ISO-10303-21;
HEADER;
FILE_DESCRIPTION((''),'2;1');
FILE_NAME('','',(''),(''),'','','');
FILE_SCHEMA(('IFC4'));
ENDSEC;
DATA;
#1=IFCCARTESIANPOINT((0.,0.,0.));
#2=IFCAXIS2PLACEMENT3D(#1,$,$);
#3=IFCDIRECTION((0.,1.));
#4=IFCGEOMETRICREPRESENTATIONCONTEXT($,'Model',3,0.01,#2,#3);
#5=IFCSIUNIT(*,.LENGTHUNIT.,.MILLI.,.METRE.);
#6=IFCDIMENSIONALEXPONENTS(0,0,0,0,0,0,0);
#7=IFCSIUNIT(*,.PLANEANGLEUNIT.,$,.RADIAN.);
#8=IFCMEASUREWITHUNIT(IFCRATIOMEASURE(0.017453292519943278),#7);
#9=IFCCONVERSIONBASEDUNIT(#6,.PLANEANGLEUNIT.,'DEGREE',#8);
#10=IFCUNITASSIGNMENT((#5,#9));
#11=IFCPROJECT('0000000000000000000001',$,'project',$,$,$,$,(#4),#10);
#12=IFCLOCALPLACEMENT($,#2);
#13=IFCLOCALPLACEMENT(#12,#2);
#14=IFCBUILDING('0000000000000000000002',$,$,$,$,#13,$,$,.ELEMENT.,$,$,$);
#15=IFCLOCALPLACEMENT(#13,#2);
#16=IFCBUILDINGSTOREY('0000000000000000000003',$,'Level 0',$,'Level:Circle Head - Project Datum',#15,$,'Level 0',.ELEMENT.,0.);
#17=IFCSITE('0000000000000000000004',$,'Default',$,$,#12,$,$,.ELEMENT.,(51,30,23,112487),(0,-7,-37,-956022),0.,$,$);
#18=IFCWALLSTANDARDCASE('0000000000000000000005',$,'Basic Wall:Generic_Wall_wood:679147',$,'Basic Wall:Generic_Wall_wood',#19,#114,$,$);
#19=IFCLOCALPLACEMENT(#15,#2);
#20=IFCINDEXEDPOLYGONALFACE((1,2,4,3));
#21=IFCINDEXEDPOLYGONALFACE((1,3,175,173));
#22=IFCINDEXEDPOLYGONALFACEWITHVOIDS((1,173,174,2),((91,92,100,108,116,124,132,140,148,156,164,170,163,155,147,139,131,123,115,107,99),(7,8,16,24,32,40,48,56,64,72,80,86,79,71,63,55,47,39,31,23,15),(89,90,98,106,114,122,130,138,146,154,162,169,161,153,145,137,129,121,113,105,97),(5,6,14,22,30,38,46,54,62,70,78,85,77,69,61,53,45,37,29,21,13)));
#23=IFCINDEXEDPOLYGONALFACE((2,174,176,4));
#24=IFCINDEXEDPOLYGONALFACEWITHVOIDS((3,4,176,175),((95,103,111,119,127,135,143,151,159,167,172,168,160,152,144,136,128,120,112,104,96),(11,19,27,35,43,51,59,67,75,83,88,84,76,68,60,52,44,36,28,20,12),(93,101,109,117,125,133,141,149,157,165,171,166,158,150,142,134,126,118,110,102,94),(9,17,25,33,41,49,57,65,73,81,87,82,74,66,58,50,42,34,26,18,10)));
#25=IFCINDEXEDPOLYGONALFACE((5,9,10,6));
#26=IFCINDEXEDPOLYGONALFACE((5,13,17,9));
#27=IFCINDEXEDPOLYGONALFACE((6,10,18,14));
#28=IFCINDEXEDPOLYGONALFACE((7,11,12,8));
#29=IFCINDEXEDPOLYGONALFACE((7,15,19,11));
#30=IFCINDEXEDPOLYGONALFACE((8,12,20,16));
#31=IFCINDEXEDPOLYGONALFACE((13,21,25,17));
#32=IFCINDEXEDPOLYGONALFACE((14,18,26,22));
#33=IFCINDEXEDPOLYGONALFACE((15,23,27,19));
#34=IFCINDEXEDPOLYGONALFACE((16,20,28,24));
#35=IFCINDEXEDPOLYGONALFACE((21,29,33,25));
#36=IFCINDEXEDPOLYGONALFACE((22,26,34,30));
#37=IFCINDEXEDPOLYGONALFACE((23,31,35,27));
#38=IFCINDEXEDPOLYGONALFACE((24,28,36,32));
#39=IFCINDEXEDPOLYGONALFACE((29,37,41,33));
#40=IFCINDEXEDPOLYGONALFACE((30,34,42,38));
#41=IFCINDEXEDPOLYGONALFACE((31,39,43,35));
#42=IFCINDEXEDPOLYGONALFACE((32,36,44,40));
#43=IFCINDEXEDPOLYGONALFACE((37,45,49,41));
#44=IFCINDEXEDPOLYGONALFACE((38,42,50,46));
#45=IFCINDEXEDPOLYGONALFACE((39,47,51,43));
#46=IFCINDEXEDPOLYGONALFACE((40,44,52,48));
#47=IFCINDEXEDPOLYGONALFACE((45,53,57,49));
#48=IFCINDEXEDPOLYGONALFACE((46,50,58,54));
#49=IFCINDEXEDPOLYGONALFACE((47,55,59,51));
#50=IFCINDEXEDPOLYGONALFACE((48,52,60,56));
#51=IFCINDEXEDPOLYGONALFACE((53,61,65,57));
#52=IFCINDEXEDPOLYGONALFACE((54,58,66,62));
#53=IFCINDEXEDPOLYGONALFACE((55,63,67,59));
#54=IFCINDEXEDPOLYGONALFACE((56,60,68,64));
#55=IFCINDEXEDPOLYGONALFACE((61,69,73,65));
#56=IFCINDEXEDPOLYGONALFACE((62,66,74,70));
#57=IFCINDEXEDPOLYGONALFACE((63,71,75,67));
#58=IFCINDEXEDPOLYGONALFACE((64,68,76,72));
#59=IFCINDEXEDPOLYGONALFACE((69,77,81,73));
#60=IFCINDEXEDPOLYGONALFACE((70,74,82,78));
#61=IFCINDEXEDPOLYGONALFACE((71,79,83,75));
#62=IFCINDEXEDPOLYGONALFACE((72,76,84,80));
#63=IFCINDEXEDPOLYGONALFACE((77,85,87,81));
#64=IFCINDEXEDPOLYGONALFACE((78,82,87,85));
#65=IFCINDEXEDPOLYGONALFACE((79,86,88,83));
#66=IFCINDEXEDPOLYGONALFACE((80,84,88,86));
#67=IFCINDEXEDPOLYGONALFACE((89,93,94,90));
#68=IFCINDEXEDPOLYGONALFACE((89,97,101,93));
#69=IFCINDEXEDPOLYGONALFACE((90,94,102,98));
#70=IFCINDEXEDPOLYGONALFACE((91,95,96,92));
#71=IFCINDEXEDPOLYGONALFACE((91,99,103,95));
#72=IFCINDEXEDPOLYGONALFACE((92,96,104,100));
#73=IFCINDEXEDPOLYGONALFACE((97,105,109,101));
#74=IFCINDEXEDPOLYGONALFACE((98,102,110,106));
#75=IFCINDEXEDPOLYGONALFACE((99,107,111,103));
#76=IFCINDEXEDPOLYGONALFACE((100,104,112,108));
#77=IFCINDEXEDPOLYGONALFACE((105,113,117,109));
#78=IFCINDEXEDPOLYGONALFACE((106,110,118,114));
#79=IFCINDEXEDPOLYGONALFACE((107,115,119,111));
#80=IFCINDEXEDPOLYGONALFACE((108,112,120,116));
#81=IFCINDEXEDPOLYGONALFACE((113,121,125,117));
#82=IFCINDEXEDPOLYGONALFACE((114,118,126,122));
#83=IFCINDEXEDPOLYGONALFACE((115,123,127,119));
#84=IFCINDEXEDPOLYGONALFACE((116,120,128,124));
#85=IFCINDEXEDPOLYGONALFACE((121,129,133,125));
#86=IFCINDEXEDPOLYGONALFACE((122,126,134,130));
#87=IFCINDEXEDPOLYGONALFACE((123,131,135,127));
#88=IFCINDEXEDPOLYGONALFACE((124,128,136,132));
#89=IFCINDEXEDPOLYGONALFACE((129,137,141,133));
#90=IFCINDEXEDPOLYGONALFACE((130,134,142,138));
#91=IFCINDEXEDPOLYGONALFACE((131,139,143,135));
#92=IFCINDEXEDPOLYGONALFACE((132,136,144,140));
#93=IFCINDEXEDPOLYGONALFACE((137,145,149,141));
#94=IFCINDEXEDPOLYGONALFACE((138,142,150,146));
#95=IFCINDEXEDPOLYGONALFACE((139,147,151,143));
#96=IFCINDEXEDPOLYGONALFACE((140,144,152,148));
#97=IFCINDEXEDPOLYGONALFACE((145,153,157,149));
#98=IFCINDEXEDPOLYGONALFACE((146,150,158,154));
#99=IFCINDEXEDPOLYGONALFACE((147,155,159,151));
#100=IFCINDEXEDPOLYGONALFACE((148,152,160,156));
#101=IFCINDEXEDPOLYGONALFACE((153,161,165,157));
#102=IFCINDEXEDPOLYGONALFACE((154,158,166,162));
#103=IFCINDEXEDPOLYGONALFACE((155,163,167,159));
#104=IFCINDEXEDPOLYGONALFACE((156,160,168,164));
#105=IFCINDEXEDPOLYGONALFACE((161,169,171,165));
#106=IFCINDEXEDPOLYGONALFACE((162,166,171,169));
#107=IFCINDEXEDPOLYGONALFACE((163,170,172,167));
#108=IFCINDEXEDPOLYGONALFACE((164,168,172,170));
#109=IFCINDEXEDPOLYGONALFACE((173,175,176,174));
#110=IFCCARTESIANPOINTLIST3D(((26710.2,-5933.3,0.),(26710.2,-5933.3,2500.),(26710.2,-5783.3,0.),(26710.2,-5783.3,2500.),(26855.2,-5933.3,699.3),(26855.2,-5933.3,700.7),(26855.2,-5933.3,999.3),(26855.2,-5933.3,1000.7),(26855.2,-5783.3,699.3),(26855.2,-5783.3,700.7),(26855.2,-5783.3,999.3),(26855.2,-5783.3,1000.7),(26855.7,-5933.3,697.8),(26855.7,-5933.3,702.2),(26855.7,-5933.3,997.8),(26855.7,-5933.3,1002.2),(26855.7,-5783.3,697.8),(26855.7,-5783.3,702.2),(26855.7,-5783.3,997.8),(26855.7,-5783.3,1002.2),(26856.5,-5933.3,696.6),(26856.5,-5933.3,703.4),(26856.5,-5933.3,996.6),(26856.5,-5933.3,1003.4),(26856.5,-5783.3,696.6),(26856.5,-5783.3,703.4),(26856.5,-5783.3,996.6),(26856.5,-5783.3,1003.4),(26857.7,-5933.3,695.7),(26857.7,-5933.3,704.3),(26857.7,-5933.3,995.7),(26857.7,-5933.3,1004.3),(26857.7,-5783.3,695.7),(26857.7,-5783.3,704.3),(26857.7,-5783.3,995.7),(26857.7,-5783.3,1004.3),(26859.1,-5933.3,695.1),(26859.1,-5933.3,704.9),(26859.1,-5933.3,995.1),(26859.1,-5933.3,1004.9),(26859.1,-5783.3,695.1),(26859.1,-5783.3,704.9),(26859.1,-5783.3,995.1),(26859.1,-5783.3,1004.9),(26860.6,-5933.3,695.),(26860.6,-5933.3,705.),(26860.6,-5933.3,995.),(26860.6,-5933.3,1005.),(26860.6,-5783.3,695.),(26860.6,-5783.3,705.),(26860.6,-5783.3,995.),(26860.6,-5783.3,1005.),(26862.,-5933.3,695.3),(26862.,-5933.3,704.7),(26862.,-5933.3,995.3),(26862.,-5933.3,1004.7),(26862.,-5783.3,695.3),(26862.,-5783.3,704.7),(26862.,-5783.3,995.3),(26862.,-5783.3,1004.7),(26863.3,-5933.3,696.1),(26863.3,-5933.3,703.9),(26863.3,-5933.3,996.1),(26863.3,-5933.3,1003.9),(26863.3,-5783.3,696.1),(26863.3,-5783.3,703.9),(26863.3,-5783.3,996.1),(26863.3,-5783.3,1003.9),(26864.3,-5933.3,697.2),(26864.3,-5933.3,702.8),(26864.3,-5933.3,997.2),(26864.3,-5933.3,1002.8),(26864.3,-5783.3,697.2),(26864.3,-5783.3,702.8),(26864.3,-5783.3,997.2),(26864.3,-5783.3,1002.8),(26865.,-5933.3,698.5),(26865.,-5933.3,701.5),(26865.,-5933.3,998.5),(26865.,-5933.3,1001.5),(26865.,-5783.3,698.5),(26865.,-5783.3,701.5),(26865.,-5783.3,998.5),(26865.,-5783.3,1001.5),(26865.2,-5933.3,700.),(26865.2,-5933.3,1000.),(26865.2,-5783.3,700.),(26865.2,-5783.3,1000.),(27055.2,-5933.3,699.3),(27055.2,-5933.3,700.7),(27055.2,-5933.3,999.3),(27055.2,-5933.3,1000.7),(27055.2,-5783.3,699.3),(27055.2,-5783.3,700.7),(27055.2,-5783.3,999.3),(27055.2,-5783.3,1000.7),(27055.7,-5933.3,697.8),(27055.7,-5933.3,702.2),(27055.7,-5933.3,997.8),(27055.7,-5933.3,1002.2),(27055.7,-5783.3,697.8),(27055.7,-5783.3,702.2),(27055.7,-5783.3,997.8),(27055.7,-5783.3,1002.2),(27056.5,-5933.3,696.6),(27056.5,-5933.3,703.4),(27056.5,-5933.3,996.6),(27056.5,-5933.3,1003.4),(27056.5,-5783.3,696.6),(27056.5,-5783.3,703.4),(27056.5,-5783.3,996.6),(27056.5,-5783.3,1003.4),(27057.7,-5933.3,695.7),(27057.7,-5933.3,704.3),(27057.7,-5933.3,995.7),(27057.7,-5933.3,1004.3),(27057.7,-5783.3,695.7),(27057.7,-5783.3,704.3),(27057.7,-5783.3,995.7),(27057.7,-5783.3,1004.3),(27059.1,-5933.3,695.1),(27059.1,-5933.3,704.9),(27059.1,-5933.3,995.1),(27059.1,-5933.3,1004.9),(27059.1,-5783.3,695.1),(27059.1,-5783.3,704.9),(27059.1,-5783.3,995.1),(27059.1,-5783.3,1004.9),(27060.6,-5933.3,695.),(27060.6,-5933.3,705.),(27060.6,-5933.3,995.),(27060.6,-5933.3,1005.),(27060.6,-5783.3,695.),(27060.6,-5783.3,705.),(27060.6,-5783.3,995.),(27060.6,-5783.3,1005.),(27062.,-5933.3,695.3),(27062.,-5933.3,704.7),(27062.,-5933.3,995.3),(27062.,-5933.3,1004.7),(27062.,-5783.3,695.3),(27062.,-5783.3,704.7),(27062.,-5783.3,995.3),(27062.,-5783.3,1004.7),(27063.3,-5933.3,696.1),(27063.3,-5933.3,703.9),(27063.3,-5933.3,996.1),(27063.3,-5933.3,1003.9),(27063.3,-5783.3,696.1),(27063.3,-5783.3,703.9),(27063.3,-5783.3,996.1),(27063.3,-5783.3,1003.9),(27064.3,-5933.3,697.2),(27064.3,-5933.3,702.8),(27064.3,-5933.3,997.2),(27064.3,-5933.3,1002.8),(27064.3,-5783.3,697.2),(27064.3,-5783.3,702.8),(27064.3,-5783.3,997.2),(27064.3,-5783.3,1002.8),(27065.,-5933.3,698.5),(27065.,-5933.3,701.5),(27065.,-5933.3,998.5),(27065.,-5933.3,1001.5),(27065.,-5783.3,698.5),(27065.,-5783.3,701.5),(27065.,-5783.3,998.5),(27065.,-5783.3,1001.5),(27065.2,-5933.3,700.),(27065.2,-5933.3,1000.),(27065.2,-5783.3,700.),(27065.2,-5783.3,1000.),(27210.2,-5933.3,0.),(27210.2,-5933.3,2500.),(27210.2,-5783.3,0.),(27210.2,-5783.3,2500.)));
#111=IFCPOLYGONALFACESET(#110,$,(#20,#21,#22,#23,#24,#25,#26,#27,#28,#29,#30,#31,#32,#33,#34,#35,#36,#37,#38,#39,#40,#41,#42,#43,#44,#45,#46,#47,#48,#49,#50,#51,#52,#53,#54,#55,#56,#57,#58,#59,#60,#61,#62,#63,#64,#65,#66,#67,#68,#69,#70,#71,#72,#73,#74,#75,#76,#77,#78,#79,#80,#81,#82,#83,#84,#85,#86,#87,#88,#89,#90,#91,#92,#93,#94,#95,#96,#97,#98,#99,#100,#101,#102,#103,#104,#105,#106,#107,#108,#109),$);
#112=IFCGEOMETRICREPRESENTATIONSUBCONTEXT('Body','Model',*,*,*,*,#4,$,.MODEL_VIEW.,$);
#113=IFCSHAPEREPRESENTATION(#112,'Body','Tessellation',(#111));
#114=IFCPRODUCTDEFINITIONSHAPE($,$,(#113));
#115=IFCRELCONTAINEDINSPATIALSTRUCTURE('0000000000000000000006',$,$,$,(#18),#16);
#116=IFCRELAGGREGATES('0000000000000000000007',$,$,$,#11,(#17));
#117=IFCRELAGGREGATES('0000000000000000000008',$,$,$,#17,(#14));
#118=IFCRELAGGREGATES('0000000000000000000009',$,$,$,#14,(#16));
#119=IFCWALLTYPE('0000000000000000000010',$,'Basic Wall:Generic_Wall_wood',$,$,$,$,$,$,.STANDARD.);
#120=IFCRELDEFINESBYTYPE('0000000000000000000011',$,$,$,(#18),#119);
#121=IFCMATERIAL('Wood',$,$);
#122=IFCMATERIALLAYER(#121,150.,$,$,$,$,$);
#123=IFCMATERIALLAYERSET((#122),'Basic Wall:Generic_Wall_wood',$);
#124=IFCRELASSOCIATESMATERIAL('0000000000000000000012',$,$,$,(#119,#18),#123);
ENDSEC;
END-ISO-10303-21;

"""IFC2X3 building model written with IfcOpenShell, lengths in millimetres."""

from ifc_helpers import new_model, entity, si_unit, converted_unit, direction, frame, frame_2d, origin, origin_2d_with_axis, place, context, subcontext, project, spatial, rectangle, circle, extrude, material, layer, layer_set, layer_usage, type_object, element, save


model = new_model("IFC2X3")

# Units and contexts
model_context = context("Model", 3, precision=0.01, world=origin(), true_north=direction((0.0, 1.0)))
body_context = subcontext(model_context, "Body", "Model", "MODEL_VIEW")
ifc_project = project(units=[si_unit("LENGTHUNIT", "METRE", prefix="MILLI"), converted_unit("PLANEANGLEUNIT", "DEGREE", entity("IfcRatioMeasure", 0.017453292519943278), si_unit("PLANEANGLEUNIT", "RADIAN"), dimensions=[0, 0, 0, 0, 0, 0, 0])], contexts=[model_context])

# Site, building, storey
site_placement = place(None, origin())
site = spatial("IfcSite", under=ifc_project, at=site_placement, Name="Default", CompositionType="ELEMENT", RefLatitude=(51, 30, 23, 112487), RefLongitude=(0, -7, -37, -956022), RefElevation=0.0)
building_placement = place(site_placement, origin())
building = spatial("IfcBuilding", under=site, at=building_placement, CompositionType="ELEMENT")
storey_placement = place(building_placement, origin())
storey = spatial("IfcBuildingStorey", under=building, at=storey_placement, Name="Level 0", ObjectType="Level:Circle Head - Project Datum", LongName="Level 0", CompositionType="ELEMENT", Elevation=0.0)

# Wall, openings
ifc_material_1 = material(Name="Wood")
ifc_layer_1 = layer(ifc_material_1, 150.0)
ifc_layer_set_1 = layer_set([ifc_layer_1], Name="Basic Wall:Generic_Wall_wood")
ifc_layer_usage_1 = layer_usage(ifc_layer_set_1, "AXIS2", "NEGATIVE", 75.0)
wall_type_1 = type_object("IfcWallType", Name="Basic Wall:Generic_Wall_wood", PredefinedType="STANDARD", material=ifc_layer_set_1)
wall_1_placement = place(storey_placement, frame((27210.2, -5858.3, 0.0), z_axis=(0.0, 0.0, 1.0), x_axis=(-1.0, 0.0, 0.0)))
wall_1 = element("IfcWallStandardCase", 1, at=wall_1_placement, inside=storey, type_object=wall_type_1, material=ifc_layer_usage_1, Name="Basic Wall:Generic_Wall_wood:679147", ObjectType="Basic Wall:Generic_Wall_wood", context=body_context, shape_type="SweptSolid", body=[
    extrude(rectangle(XDim=500.0, YDim=150.0, at=frame_2d((250.0, 0.0), x_axis=(-1.0, 0.0))), origin(), (0.0, 0.0, 1.0), 2500.0),
])
opening_1_placement = place(wall_1_placement, origin())
element("IfcOpeningElement", 2, at=opening_1_placement, cuts=wall_1, ObjectType="Opening", context=body_context, shape_type="SweptSolid", body=[
    extrude(circle(Radius=5.0, at=origin_2d_with_axis()), frame((150.0, -75.0, 700.0), z_axis=(0.0, 1.0, 0.0), x_axis=(-1.0, 0.0, 0.0)), (0.0, 0.0, 1.0), 200.0),
])
opening_2_placement = place(wall_1_placement, origin())
element("IfcOpeningElement", 3, at=opening_2_placement, cuts=wall_1, ObjectType="Opening", context=body_context, shape_type="SweptSolid", body=[
    extrude(circle(Radius=5.0, at=origin_2d_with_axis()), frame((350.0, -75.0, 700.0), z_axis=(0.0, 1.0, 0.0), x_axis=(-1.0, 0.0, 0.0)), (0.0, 0.0, 1.0), 200.0),
])
opening_3_placement = place(wall_1_placement, origin())
element("IfcOpeningElement", 4, at=opening_3_placement, cuts=wall_1, ObjectType="Opening", context=body_context, shape_type="SweptSolid", body=[
    extrude(circle(Radius=5.0, at=origin_2d_with_axis()), frame((150.0, -75.0, 1000.0), z_axis=(0.0, 1.0, 0.0), x_axis=(-1.0, 0.0, 0.0)), (0.0, 0.0, 1.0), 200.0),
])
opening_4_placement = place(wall_1_placement, origin())
element("IfcOpeningElement", 5, at=opening_4_placement, cuts=wall_1, ObjectType="Opening", context=body_context, shape_type="SweptSolid", body=[
    extrude(circle(Radius=5.0, at=origin_2d_with_axis()), frame((350.0, -75.0, 1000.0), z_axis=(0.0, 1.0, 0.0), x_axis=(-1.0, 0.0, 0.0)), (0.0, 0.0, 1.0), 200.0),
])

save(model, "model.ifc")
